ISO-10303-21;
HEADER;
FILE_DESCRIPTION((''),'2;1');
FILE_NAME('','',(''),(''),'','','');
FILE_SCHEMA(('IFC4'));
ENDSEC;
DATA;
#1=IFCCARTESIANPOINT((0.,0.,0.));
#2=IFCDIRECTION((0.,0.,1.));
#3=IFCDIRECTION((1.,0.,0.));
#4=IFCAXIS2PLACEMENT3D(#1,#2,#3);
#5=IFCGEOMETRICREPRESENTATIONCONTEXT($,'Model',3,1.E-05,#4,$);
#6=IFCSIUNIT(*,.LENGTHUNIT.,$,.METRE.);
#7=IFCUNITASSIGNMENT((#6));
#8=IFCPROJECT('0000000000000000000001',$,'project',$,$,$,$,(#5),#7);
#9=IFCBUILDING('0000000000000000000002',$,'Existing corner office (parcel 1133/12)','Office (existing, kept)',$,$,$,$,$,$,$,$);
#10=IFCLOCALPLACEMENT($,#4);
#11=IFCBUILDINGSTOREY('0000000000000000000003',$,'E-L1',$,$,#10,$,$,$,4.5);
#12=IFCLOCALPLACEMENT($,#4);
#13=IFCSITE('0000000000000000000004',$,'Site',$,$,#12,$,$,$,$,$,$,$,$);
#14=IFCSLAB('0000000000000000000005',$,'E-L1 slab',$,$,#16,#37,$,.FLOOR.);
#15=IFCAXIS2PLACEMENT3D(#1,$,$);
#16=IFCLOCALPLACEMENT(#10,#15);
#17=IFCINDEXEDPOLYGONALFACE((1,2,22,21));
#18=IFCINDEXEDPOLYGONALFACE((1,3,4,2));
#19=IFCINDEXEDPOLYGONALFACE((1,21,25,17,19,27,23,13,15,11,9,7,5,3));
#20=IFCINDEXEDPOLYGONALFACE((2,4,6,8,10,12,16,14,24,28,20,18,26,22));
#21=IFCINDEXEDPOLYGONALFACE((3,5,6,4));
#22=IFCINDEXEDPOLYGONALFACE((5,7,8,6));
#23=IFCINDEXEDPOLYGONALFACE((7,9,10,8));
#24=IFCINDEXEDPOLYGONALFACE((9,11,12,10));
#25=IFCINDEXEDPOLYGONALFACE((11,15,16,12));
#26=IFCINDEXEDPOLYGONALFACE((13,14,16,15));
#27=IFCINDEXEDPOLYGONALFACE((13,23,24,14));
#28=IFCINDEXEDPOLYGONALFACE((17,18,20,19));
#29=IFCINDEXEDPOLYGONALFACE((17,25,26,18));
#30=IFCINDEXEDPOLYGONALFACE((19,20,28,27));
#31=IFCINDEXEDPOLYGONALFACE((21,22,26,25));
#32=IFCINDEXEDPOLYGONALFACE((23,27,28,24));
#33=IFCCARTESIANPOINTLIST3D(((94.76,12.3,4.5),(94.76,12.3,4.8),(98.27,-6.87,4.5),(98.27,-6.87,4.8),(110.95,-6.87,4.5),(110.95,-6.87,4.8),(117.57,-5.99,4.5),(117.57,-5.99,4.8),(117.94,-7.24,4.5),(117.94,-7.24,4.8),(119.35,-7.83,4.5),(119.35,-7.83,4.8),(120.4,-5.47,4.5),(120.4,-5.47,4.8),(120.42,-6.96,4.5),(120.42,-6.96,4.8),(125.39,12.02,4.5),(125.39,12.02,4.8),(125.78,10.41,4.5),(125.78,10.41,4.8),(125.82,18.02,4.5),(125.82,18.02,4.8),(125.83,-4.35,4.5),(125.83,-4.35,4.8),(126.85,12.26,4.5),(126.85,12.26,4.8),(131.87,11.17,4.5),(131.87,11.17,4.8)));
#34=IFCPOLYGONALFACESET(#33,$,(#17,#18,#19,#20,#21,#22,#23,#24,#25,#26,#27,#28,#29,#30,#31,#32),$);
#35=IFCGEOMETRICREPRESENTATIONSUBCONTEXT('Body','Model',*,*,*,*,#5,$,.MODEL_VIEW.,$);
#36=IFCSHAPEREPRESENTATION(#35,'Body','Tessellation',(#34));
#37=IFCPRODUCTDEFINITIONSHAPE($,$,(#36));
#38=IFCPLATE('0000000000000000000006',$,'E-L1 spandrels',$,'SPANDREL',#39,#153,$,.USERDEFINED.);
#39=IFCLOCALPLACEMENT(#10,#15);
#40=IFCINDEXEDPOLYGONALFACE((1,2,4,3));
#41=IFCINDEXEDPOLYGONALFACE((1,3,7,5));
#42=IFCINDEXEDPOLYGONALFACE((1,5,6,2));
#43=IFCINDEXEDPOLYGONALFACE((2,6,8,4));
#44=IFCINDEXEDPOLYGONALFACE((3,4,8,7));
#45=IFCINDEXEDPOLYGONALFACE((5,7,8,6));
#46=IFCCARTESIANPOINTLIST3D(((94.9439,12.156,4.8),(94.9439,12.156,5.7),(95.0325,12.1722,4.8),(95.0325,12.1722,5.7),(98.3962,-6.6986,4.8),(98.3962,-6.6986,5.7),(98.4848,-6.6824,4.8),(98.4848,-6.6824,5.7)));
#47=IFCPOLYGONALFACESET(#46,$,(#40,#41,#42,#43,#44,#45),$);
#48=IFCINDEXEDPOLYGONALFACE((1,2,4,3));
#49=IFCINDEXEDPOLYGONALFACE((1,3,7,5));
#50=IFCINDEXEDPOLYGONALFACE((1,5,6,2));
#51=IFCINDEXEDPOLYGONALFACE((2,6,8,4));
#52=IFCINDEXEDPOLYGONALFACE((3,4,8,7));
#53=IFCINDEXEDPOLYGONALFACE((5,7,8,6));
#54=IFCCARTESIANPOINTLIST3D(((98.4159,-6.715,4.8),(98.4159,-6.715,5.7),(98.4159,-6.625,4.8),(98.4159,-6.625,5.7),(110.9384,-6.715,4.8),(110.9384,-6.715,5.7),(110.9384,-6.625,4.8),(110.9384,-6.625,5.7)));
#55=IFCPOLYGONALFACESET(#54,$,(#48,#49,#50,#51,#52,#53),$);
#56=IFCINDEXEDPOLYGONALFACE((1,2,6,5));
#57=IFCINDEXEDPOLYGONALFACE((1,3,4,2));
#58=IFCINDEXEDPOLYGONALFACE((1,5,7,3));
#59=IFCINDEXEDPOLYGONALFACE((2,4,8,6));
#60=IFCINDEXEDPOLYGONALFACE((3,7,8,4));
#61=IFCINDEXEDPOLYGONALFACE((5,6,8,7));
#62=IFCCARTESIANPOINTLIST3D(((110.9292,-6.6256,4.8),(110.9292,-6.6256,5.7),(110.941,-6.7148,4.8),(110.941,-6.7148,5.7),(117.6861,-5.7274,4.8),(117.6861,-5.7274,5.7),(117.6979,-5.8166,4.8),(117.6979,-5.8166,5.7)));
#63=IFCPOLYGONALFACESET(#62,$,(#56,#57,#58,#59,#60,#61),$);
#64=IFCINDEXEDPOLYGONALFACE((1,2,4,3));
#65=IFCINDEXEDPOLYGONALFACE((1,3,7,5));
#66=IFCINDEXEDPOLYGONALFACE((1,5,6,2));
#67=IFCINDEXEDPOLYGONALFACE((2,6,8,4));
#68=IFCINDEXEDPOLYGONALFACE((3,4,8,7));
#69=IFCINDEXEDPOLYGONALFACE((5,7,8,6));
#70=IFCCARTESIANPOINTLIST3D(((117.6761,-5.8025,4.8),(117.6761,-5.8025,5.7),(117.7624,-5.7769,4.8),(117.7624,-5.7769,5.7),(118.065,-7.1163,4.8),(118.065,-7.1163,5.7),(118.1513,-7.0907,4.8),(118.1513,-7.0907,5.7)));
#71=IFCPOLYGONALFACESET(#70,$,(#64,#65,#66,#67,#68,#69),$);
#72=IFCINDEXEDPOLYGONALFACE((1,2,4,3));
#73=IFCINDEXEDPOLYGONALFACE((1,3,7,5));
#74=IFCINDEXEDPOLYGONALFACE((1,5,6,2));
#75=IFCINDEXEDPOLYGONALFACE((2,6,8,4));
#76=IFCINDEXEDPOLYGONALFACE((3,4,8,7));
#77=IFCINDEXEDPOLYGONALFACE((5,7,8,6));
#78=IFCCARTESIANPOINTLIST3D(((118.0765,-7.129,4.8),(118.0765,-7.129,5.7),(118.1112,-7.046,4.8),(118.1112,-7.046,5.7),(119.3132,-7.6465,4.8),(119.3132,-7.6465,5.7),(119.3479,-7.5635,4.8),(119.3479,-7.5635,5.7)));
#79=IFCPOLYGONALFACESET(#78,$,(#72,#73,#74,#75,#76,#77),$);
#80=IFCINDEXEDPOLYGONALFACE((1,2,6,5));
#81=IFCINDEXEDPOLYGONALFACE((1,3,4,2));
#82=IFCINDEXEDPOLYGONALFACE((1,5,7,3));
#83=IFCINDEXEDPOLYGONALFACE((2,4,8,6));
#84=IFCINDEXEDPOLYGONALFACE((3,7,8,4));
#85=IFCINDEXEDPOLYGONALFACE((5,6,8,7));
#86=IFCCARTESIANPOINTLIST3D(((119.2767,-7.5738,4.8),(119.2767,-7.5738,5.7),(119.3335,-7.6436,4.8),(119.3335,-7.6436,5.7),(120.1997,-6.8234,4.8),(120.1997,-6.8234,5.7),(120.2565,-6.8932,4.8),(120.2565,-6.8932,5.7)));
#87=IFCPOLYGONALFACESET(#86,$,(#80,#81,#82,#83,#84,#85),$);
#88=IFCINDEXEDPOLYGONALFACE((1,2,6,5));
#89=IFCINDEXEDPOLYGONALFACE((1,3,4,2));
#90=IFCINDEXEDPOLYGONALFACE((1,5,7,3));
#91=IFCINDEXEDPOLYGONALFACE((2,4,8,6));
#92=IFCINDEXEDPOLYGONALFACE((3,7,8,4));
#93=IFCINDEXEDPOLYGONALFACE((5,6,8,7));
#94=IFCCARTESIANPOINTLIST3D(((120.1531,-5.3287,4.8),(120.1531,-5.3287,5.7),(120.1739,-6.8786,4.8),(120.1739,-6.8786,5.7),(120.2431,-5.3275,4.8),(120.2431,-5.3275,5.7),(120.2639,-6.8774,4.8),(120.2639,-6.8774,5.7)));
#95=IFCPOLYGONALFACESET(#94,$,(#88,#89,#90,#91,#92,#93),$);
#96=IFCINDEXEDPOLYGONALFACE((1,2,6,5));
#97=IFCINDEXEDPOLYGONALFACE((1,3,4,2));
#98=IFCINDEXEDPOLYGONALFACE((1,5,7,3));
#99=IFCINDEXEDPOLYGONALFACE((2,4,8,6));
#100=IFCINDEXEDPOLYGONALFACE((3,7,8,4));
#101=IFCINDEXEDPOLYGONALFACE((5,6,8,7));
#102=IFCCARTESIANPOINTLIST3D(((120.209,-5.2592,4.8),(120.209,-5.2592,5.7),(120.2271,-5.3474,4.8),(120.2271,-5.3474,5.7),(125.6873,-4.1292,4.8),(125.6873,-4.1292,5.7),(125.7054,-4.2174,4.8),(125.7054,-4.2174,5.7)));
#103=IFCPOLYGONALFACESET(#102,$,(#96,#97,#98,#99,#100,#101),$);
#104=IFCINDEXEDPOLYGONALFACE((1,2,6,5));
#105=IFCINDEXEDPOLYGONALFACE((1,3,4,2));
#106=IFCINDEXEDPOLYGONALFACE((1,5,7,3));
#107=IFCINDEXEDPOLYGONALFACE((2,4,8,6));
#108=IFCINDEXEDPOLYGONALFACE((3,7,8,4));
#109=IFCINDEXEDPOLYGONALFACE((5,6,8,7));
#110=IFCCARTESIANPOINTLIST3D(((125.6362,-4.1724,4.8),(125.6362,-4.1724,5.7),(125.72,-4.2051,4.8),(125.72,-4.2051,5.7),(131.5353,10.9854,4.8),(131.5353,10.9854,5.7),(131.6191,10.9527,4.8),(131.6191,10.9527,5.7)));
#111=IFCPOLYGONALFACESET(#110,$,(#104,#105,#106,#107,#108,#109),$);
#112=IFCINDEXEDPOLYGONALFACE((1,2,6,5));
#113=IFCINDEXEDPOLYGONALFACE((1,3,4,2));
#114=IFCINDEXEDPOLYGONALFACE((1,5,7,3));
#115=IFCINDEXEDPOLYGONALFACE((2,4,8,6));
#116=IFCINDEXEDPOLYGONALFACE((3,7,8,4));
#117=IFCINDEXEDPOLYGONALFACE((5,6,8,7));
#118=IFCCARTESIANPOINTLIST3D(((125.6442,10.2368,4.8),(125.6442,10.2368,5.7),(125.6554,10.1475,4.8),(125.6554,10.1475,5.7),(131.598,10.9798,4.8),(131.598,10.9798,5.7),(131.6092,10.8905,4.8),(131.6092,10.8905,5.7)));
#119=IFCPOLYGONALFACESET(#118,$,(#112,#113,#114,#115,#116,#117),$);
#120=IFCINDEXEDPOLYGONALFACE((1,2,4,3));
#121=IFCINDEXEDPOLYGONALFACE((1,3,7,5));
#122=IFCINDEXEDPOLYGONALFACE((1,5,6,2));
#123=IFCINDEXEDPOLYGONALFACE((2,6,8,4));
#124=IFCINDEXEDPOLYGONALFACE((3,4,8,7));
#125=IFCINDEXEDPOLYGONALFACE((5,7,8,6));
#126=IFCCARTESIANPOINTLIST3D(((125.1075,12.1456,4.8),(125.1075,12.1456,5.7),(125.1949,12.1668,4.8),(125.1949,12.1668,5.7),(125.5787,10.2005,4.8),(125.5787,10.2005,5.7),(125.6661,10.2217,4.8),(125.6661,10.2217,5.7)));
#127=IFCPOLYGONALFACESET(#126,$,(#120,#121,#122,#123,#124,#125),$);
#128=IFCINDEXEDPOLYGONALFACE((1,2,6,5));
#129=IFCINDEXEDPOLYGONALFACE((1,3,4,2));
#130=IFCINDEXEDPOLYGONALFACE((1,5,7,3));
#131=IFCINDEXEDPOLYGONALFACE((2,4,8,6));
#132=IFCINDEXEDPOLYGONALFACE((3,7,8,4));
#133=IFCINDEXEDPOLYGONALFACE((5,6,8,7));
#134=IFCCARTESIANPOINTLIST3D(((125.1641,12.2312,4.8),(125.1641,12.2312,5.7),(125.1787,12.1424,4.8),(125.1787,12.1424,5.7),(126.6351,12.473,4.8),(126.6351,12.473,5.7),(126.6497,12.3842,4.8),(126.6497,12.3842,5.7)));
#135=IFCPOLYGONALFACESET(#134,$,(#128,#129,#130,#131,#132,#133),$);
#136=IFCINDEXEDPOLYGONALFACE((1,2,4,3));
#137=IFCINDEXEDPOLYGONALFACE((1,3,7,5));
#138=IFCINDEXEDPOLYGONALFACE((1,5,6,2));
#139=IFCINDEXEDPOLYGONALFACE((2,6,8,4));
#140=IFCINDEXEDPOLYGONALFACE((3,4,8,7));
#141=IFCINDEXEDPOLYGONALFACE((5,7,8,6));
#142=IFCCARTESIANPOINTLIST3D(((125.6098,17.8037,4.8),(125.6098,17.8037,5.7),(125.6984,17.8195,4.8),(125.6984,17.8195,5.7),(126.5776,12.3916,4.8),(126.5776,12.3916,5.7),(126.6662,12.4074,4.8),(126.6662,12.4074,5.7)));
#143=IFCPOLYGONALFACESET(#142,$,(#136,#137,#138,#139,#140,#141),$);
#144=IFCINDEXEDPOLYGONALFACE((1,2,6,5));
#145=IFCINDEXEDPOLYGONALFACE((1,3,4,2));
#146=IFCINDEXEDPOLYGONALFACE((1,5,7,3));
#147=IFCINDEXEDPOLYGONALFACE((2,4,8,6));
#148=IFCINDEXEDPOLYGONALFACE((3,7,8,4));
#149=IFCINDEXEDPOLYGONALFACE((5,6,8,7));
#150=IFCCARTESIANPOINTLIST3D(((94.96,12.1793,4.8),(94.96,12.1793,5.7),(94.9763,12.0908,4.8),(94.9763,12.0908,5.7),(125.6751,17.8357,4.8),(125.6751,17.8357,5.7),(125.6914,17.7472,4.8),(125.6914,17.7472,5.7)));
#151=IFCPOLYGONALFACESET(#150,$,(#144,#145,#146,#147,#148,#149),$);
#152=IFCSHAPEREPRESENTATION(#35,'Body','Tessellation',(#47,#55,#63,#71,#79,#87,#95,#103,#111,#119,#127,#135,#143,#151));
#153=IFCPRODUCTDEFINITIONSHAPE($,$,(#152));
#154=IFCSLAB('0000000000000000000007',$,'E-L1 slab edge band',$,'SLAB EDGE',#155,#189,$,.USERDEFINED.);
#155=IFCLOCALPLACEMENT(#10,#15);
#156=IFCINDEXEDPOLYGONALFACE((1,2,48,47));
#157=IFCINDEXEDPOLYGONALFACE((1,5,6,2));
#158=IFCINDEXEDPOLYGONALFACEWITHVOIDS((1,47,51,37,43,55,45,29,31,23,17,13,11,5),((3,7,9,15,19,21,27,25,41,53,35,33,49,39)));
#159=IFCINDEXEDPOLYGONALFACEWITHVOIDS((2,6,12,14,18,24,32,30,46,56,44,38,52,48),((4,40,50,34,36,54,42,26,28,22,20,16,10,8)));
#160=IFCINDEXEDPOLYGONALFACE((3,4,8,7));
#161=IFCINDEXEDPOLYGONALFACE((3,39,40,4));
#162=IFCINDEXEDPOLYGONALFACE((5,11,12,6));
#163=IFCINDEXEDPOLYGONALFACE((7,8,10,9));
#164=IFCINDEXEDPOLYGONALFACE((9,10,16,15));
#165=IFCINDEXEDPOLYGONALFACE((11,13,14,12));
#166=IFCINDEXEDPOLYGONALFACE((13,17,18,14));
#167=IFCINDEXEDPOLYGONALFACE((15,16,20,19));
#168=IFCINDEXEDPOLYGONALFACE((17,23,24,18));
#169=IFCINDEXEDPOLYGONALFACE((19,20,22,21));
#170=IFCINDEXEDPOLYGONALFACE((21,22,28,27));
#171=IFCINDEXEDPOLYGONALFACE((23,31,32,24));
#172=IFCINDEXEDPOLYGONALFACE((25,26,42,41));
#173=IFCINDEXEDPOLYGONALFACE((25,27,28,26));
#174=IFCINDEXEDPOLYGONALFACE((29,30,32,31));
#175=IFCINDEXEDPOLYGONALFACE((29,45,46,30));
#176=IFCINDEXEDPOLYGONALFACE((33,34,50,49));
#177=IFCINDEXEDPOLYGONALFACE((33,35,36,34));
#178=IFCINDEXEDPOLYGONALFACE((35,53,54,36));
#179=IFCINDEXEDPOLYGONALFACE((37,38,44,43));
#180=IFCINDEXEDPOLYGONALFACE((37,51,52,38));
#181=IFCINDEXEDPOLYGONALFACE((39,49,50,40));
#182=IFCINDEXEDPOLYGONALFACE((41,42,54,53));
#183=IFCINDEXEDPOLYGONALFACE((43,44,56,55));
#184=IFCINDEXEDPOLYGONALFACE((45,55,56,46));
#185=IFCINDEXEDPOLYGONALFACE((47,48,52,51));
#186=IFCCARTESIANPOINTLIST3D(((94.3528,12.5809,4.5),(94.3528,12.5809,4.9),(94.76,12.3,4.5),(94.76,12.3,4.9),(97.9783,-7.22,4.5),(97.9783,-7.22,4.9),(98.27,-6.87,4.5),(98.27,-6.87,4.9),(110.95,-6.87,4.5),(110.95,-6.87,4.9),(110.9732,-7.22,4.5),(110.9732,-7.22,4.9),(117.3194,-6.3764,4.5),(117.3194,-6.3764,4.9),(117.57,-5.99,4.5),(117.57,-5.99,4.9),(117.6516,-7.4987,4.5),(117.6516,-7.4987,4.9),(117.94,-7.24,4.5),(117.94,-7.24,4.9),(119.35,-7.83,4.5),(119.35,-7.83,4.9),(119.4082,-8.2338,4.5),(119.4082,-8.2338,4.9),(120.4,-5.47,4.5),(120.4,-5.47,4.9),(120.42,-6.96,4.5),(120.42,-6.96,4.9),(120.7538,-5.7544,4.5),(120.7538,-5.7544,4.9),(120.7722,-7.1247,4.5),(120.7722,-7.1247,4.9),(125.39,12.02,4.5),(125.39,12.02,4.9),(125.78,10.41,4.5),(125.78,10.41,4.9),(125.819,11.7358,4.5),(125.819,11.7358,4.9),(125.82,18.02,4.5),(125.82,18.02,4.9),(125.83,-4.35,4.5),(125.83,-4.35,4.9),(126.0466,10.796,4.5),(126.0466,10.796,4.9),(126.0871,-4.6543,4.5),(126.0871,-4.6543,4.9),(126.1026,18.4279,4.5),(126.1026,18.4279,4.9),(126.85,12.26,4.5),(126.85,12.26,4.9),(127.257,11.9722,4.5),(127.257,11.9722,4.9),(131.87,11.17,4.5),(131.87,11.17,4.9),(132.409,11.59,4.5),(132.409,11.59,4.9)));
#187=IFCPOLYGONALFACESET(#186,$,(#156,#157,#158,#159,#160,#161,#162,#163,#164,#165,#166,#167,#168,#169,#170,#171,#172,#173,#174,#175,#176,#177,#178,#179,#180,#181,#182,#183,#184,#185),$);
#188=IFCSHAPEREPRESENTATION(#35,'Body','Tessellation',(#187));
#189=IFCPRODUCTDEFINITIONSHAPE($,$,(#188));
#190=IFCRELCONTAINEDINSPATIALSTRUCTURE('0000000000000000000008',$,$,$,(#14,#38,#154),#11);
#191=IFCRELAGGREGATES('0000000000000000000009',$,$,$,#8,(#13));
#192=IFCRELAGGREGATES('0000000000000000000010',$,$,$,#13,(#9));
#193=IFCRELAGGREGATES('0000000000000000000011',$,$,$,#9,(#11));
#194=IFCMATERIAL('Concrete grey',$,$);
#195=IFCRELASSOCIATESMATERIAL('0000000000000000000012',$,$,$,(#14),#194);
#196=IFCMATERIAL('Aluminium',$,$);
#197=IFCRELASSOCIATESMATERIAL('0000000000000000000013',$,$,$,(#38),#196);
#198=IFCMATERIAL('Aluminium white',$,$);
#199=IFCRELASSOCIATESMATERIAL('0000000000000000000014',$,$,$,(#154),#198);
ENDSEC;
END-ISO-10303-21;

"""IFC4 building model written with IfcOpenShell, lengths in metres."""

from ifc_helpers import new_model, si_unit, frame, origin_with_axes, place, context, subcontext, project, spatial, polyline, outline, extrude, material, element, save


model = new_model("IFC4")

# Units and contexts
model_context = context("Model", 3, precision=1e-05, world=origin_with_axes())
body_context = subcontext(model_context, "Body", "Model", "MODEL_VIEW")
ifc_project = project(units=[si_unit("LENGTHUNIT", "METRE")], contexts=[model_context])

# Site, building, storey
site_placement = place(None, origin_with_axes())
site = spatial("IfcSite", under=ifc_project, at=site_placement, Name="Site")
building = spatial("IfcBuilding", under=site, Name="Existing corner office (parcel 1133/12)", Description="Office (existing, kept)")
storey_placement = place(None, origin_with_axes())
storey = spatial("IfcBuildingStorey", under=building, at=storey_placement, Name="E-L1", Elevation=4.5)

# Shared definitions
ifc_material_1 = material(Name="Aluminium")

# Slab
ifc_material_2 = material(Name="Concrete grey")
slab_1_placement = place(storey_placement, origin_with_axes())
element("IfcSlab", 1, at=slab_1_placement, inside=storey, material=ifc_material_2, Name="E-L1 slab", PredefinedType="FLOOR", context=body_context, shape_type="SweptSolid", body=[
    extrude(outline(polyline([(94.76, 12.3), (98.27, -6.87), (110.95, -6.87), (117.57, -5.99), (117.94, -7.24), (119.35, -7.83), (120.42, -6.96), (120.4, -5.47), (125.83, -4.35), (131.87, 11.17), (125.78, 10.41), (125.39, 12.02), (126.85, 12.26), (125.82, 18.02), (94.76, 12.3)])), frame((0.0, 0.0, 4.5), z_axis=(0.0, 0.0, 1.0), x_axis=(1.0, 0.0, 0.0)), (0.0, 0.0, 1.0), 0.3),
])

# Plate
plate_placement = place(storey_placement, origin_with_axes())
element("IfcPlate", 2, at=plate_placement, inside=storey, material=ifc_material_1, Name="E-L1 spandrels", ObjectType="SPANDREL", PredefinedType="USERDEFINED", context=body_context, shape_type="SweptSolid", body=[
    extrude(outline(polyline([(94.9439, 12.156), (98.3962, -6.6986), (98.4848, -6.6824), (95.0325, 12.1722), (94.9439, 12.156)])), frame((0.0, 0.0, 4.8), z_axis=(0.0, 0.0, 1.0), x_axis=(1.0, 0.0, 0.0)), (0.0, 0.0, 1.0), 0.9),
    extrude(outline(polyline([(98.4159, -6.715), (110.9384, -6.715), (110.9384, -6.625), (98.4159, -6.625), (98.4159, -6.715)])), frame((0.0, 0.0, 4.8), z_axis=(0.0, 0.0, 1.0), x_axis=(1.0, 0.0, 0.0)), (0.0, 0.0, 1.0), 0.9),
    extrude(outline(polyline([(110.941, -6.7148), (117.6979, -5.8166), (117.6861, -5.7274), (110.9292, -6.6256), (110.941, -6.7148)])), frame((0.0, 0.0, 4.8), z_axis=(0.0, 0.0, 1.0), x_axis=(1.0, 0.0, 0.0)), (0.0, 0.0, 1.0), 0.9),
    extrude(outline(polyline([(117.6761, -5.8025), (118.065, -7.1163), (118.1513, -7.0907), (117.7624, -5.7769), (117.6761, -5.8025)])), frame((0.0, 0.0, 4.8), z_axis=(0.0, 0.0, 1.0), x_axis=(1.0, 0.0, 0.0)), (0.0, 0.0, 1.0), 0.9),
    extrude(outline(polyline([(118.0765, -7.129), (119.3132, -7.6465), (119.3479, -7.5635), (118.1112, -7.046), (118.0765, -7.129)])), frame((0.0, 0.0, 4.8), z_axis=(0.0, 0.0, 1.0), x_axis=(1.0, 0.0, 0.0)), (0.0, 0.0, 1.0), 0.9),
    extrude(outline(polyline([(119.3335, -7.6436), (120.2565, -6.8932), (120.1997, -6.8234), (119.2767, -7.5738), (119.3335, -7.6436)])), frame((0.0, 0.0, 4.8), z_axis=(0.0, 0.0, 1.0), x_axis=(1.0, 0.0, 0.0)), (0.0, 0.0, 1.0), 0.9),
    extrude(outline(polyline([(120.2639, -6.8774), (120.2431, -5.3275), (120.1531, -5.3287), (120.1739, -6.8786), (120.2639, -6.8774)])), frame((0.0, 0.0, 4.8), z_axis=(0.0, 0.0, 1.0), x_axis=(1.0, 0.0, 0.0)), (0.0, 0.0, 1.0), 0.9),
    extrude(outline(polyline([(120.2271, -5.3474), (125.7054, -4.2174), (125.6873, -4.1292), (120.209, -5.2592), (120.2271, -5.3474)])), frame((0.0, 0.0, 4.8), z_axis=(0.0, 0.0, 1.0), x_axis=(1.0, 0.0, 0.0)), (0.0, 0.0, 1.0), 0.9),
    extrude(outline(polyline([(125.72, -4.2051), (131.6191, 10.9527), (131.5353, 10.9854), (125.6362, -4.1724), (125.72, -4.2051)])), frame((0.0, 0.0, 4.8), z_axis=(0.0, 0.0, 1.0), x_axis=(1.0, 0.0, 0.0)), (0.0, 0.0, 1.0), 0.9),
    extrude(outline(polyline([(131.598, 10.9798), (125.6442, 10.2368), (125.6554, 10.1475), (131.6092, 10.8905), (131.598, 10.9798)])), frame((0.0, 0.0, 4.8), z_axis=(0.0, 0.0, 1.0), x_axis=(1.0, 0.0, 0.0)), (0.0, 0.0, 1.0), 0.9),
    extrude(outline(polyline([(125.6661, 10.2217), (125.1949, 12.1668), (125.1075, 12.1456), (125.5787, 10.2005), (125.6661, 10.2217)])), frame((0.0, 0.0, 4.8), z_axis=(0.0, 0.0, 1.0), x_axis=(1.0, 0.0, 0.0)), (0.0, 0.0, 1.0), 0.9),
    extrude(outline(polyline([(125.1787, 12.1424), (126.6497, 12.3842), (126.6351, 12.473), (125.1641, 12.2312), (125.1787, 12.1424)])), frame((0.0, 0.0, 4.8), z_axis=(0.0, 0.0, 1.0), x_axis=(1.0, 0.0, 0.0)), (0.0, 0.0, 1.0), 0.9),
    extrude(outline(polyline([(126.6662, 12.4074), (125.6984, 17.8195), (125.6098, 17.8037), (126.5776, 12.3916), (126.6662, 12.4074)])), frame((0.0, 0.0, 4.8), z_axis=(0.0, 0.0, 1.0), x_axis=(1.0, 0.0, 0.0)), (0.0, 0.0, 1.0), 0.9),
    extrude(outline(polyline([(125.6751, 17.8357), (94.96, 12.1793), (94.9763, 12.0908), (125.6914, 17.7472), (125.6751, 17.8357)])), frame((0.0, 0.0, 4.8), z_axis=(0.0, 0.0, 1.0), x_axis=(1.0, 0.0, 0.0)), (0.0, 0.0, 1.0), 0.9),
])

# Slab
ifc_material_3 = material(Name="Aluminium white")
slab_2_placement = place(storey_placement, origin_with_axes())
element("IfcSlab", 3, at=slab_2_placement, inside=storey, material=ifc_material_3, Name="E-L1 slab edge band", ObjectType="SLAB EDGE", PredefinedType="USERDEFINED", context=body_context, shape_type="SweptSolid", body=[
    extrude(outline(polyline([(94.3528, 12.5809), (97.9783, -7.22), (110.9732, -7.22), (117.3194, -6.3764), (117.6516, -7.4987), (119.4082, -8.2338), (120.7722, -7.1247), (120.7538, -5.7544), (126.0871, -4.6543), (132.409, 11.59), (126.0466, 10.796), (125.819, 11.7358), (127.257, 11.9722), (126.1026, 18.4279), (94.3528, 12.5809)]), holes=[polyline([(94.76, 12.3), (98.27, -6.87), (110.95, -6.87), (117.57, -5.99), (117.94, -7.24), (119.35, -7.83), (120.42, -6.96), (120.4, -5.47), (125.83, -4.35), (131.87, 11.17), (125.78, 10.41), (125.39, 12.02), (126.85, 12.26), (125.82, 18.02), (94.76, 12.3)])]), frame((0.0, 0.0, 4.5), z_axis=(0.0, 0.0, 1.0), x_axis=(1.0, 0.0, 0.0)), (0.0, 0.0, 1.0), 0.4),
])

save(model, "model.ifc")
